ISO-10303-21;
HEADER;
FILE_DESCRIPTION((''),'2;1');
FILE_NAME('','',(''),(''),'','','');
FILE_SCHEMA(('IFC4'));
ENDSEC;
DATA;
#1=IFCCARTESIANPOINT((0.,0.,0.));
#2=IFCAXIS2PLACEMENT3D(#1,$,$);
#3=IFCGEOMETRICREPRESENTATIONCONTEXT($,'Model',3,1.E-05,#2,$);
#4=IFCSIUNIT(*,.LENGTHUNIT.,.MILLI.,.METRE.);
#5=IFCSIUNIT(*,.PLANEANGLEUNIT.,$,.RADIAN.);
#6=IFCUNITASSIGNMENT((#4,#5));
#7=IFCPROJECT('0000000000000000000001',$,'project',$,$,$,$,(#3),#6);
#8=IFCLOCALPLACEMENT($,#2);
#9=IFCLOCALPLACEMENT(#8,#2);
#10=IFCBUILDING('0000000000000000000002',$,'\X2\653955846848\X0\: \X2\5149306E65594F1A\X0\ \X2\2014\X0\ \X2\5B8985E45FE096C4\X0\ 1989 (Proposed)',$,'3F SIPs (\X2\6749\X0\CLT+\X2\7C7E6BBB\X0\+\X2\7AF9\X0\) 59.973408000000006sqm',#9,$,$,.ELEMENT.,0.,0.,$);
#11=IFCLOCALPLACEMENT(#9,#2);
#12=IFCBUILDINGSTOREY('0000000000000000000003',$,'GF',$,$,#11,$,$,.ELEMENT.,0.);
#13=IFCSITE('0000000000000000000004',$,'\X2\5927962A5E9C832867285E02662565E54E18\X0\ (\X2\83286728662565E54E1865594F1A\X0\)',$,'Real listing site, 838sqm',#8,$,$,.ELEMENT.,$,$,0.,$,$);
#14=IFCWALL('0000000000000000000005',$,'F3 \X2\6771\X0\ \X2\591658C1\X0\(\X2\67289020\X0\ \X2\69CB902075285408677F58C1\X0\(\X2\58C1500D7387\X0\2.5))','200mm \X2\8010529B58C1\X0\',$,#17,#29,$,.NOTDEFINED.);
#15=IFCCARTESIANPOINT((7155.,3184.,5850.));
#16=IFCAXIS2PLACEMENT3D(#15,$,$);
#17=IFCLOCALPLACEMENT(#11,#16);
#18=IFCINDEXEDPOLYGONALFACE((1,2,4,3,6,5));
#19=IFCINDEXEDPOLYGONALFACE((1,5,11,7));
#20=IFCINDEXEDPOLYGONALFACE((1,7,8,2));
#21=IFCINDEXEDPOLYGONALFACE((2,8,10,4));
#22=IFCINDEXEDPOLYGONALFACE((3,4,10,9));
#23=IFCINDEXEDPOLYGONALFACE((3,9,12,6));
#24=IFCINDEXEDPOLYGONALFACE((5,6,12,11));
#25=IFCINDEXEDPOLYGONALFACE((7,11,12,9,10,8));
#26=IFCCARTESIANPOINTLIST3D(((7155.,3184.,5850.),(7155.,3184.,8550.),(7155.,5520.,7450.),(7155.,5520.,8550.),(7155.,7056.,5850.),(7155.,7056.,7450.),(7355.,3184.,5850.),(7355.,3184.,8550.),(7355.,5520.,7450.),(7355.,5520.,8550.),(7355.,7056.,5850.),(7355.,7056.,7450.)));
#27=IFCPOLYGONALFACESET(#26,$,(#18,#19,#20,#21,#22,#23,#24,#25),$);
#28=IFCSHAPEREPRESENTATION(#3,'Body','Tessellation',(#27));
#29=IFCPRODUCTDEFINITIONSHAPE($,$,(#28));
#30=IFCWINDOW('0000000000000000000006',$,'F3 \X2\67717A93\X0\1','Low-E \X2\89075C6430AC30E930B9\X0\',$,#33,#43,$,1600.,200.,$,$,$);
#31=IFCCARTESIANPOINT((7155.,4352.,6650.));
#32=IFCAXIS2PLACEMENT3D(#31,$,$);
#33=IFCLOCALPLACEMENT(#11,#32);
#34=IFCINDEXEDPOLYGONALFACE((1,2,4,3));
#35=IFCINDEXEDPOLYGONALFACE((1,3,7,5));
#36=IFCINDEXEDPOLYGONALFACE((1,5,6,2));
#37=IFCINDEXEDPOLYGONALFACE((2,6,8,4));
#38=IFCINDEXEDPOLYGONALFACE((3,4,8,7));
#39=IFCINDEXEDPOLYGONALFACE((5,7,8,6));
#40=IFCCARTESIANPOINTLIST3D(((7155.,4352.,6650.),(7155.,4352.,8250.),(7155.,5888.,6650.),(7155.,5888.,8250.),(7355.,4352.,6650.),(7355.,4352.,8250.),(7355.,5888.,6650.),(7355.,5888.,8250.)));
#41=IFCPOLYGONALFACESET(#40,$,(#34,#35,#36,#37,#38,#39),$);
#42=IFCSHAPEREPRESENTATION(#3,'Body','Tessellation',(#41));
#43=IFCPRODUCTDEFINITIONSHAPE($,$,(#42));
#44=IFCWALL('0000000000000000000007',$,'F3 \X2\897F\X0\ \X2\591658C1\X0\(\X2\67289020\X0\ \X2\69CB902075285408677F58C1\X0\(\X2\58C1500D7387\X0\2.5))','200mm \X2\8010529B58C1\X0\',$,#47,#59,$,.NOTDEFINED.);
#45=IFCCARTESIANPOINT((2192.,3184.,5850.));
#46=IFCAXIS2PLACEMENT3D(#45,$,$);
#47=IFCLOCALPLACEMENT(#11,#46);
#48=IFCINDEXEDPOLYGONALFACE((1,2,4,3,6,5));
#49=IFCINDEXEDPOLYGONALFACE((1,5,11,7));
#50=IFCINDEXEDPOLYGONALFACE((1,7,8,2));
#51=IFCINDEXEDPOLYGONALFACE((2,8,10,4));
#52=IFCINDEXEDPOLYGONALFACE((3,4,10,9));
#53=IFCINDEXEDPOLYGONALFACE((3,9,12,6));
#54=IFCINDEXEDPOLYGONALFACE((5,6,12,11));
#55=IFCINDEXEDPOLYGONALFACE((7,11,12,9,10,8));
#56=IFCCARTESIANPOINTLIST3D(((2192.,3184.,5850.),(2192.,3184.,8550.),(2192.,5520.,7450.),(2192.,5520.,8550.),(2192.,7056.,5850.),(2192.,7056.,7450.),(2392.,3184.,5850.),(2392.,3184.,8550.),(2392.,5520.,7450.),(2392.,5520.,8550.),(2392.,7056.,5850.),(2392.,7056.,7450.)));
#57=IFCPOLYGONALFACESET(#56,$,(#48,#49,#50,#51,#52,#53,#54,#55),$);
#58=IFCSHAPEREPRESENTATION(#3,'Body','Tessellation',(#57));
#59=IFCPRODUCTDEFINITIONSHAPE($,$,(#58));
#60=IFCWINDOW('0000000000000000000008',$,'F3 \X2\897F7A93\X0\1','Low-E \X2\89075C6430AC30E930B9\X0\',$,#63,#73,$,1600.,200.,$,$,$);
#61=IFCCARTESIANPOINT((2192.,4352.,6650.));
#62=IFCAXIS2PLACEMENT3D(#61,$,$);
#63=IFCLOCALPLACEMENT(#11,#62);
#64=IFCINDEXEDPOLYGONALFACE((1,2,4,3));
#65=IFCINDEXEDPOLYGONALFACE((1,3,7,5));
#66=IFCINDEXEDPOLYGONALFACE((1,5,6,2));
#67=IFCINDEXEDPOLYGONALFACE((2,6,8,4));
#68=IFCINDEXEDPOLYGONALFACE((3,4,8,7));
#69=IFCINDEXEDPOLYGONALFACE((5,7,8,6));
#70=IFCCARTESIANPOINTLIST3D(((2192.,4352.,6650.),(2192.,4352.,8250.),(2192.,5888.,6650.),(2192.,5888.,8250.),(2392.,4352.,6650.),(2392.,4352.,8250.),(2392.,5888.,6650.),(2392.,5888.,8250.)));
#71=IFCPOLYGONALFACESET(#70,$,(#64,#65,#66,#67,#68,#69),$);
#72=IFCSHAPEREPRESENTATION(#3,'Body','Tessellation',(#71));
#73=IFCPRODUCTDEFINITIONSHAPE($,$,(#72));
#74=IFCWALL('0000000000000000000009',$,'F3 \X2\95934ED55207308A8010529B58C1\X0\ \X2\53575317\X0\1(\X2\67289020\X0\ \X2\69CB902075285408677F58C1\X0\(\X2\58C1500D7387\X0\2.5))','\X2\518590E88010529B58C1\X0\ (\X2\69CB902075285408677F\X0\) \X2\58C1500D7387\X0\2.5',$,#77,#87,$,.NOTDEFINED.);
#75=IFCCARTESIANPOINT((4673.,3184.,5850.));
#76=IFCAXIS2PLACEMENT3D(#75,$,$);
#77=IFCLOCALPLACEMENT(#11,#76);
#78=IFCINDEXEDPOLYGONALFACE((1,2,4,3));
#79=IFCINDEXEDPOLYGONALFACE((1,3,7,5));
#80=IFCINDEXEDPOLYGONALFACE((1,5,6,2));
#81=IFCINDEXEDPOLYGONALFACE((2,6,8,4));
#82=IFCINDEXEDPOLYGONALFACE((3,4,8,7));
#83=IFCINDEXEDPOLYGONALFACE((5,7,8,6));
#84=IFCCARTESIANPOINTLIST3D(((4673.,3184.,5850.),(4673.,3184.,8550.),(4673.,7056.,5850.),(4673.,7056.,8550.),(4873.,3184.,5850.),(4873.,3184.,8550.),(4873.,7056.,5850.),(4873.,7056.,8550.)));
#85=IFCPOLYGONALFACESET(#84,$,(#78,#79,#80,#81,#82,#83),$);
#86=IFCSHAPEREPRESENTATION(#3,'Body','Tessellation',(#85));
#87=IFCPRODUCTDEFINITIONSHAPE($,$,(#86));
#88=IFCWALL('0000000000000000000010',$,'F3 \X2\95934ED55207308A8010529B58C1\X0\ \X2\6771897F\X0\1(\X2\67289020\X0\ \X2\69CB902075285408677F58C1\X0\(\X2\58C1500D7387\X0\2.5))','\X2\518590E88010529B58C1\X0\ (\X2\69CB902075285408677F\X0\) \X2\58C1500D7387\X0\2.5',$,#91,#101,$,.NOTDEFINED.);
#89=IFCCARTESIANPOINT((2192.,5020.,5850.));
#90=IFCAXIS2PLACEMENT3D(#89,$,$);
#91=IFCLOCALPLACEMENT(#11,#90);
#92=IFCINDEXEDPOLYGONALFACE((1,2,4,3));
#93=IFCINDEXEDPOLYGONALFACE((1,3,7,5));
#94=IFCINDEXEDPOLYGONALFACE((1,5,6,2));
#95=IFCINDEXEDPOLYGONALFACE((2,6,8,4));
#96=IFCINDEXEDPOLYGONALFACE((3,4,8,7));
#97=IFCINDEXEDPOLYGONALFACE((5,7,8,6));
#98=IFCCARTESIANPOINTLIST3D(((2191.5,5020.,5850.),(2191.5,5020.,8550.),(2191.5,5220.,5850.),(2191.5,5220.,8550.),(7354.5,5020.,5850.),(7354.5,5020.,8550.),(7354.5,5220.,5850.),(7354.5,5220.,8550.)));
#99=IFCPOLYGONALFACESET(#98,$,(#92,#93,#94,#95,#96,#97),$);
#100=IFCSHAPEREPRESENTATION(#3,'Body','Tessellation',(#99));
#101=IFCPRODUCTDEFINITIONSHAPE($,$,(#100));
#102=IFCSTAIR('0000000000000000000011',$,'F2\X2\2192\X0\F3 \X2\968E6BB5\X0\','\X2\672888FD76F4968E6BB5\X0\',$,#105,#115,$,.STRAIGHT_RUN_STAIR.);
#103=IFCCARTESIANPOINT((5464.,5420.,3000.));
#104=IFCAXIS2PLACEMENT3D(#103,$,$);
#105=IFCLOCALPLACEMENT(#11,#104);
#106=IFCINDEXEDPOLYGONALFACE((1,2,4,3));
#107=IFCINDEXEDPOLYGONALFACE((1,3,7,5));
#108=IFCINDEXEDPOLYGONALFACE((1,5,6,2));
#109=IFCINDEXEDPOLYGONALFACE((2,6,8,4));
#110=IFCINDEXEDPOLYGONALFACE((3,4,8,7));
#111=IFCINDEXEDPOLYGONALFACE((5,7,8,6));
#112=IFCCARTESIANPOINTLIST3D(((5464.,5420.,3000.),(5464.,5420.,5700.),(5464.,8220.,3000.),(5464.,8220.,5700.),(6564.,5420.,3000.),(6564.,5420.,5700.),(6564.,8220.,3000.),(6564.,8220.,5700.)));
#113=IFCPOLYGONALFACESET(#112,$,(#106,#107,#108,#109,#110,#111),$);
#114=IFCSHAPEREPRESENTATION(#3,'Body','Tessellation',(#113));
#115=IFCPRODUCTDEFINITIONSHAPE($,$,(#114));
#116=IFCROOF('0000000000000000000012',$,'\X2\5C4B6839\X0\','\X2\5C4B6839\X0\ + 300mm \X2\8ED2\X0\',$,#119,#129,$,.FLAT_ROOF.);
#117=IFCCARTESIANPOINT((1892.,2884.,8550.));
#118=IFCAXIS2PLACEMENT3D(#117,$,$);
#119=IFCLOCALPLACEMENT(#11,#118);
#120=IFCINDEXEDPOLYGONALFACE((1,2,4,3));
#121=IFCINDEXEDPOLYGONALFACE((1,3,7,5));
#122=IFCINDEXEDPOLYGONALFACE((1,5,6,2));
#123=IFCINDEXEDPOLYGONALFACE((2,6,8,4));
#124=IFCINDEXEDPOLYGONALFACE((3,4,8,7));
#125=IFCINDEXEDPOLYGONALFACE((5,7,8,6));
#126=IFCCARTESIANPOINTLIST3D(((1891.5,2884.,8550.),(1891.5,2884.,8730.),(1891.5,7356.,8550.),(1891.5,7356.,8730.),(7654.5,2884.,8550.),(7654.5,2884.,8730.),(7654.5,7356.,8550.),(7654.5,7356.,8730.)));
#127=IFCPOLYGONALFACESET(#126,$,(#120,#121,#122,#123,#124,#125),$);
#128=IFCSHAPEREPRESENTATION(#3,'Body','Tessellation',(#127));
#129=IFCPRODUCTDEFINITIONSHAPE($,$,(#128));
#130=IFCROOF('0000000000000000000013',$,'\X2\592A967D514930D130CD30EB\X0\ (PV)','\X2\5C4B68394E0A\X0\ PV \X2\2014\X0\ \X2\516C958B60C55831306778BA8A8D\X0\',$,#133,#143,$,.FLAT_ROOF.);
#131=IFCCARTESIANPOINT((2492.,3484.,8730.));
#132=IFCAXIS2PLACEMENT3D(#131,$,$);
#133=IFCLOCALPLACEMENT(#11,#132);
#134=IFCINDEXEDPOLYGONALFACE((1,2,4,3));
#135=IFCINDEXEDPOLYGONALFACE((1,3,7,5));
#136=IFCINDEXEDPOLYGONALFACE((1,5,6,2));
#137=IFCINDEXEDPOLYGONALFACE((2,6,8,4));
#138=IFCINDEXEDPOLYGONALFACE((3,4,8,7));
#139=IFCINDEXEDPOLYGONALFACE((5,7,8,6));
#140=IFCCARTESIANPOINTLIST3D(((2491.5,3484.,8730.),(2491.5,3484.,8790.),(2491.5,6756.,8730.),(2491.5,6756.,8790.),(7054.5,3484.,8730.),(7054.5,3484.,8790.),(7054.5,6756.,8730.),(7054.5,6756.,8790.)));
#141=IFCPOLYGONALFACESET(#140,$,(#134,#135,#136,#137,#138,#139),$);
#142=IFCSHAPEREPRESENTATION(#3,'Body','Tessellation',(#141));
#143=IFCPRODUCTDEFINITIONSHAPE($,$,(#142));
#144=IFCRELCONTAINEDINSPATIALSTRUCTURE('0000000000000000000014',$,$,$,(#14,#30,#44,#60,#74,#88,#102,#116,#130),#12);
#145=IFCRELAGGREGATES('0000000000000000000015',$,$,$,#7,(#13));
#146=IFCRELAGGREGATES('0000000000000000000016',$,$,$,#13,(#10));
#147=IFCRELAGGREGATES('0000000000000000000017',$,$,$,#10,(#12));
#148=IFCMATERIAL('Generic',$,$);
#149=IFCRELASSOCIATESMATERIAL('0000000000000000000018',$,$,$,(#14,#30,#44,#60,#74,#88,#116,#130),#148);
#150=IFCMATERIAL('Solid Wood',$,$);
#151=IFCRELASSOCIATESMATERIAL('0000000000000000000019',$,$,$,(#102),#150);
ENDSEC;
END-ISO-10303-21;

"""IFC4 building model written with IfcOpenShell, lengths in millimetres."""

from ifc_helpers import new_model, si_unit, frame, frame_2d, origin, place, context, project, spatial, rectangle, extrude, material, element, fill, save


model = new_model("IFC4")

# Units and contexts
model_context = context("Model", 3, precision=1e-05, world=origin())
ifc_project = project(units=[si_unit("LENGTHUNIT", "METRE", prefix="MILLI"), si_unit("PLANEANGLEUNIT", "RADIAN")], contexts=[model_context])

# Site, building, storey
site_placement = place(None, origin())
site = spatial("IfcSite", under=ifc_project, at=site_placement, Name="大阪府茨木市春日丘 (茨木春日丘教会)", ObjectType="Real listing site, 838sqm", CompositionType="ELEMENT", RefElevation=0.0)
building_placement = place(site_placement, origin())
building = spatial("IfcBuilding", under=site, at=building_placement, Name="改善案: 光の教会 — 安藤忠雄 1989 (Proposed)", ObjectType="3F SIPs (杉CLT+籾殻+竹) 59.973408000000006sqm", CompositionType="ELEMENT", ElevationOfRefHeight=0.0, ElevationOfTerrain=0.0)
storey_placement = place(building_placement, origin())
storey = spatial("IfcBuildingStorey", under=building, at=storey_placement, Name="GF", CompositionType="ELEMENT", Elevation=0.0)

# Shared definitions
ifc_material_1 = material(Name="Generic")

# Walls, openings, windows
wall_1_placement = place(storey_placement, frame((7155.0, 3184.0, 5850.0)))
wall_1 = element("IfcWall", 1, at=wall_1_placement, inside=storey, material=ifc_material_1, Name="F3 東 外壁(木造 構造用合板壁(壁倍率2.5))", Description="200mm 耐力壁", PredefinedType="NOTDEFINED", context=model_context, shape_type="SweptSolid", body=[
    extrude(rectangle(XDim=200.0, YDim=3872.0, at=frame_2d((100.0, 1936.0))), frame((7155.0, 3184.0, 5850.0)), (0.0, 0.0, 1.0), 2700.0),
])
opening_1_placement = place(storey_placement, frame((7155.0, 4352.0, 6650.0)))
opening_1 = element("IfcOpeningElement", 2, at=opening_1_placement, cuts=wall_1, PredefinedType="NOTDEFINED", context=model_context, shape_type="SweptSolid", body=[
    extrude(rectangle(XDim=200.0, YDim=1536.0, at=frame_2d((100.0, 768.0))), frame((7155.0, 4352.0, 6650.0)), (0.0, 0.0, 1.0), 1600.0),
])
window_1_placement = place(storey_placement, frame((7155.0, 4352.0, 6650.0)))
window_1 = element("IfcWindow", 3, at=window_1_placement, inside=storey, material=ifc_material_1, Name="F3 東窓1", Description="Low-E 複層ガラス", OverallHeight=1600.0, OverallWidth=200.0, context=model_context, shape_type="SweptSolid", body=[
    extrude(rectangle(XDim=200.0, YDim=1536.0, at=frame_2d((100.0, 768.0))), frame((7155.0, 4352.0, 6650.0)), (0.0, 0.0, 1.0), 1600.0),
])
fill(opening_1, window_1)
wall_2_placement = place(storey_placement, frame((2192.0, 3184.0, 5850.0)))
wall_2 = element("IfcWall", 4, at=wall_2_placement, inside=storey, material=ifc_material_1, Name="F3 西 外壁(木造 構造用合板壁(壁倍率2.5))", Description="200mm 耐力壁", PredefinedType="NOTDEFINED", context=model_context, shape_type="SweptSolid", body=[
    extrude(rectangle(XDim=200.0, YDim=3872.0, at=frame_2d((100.0, 1936.0))), frame((2192.0, 3184.0, 5850.0)), (0.0, 0.0, 1.0), 2700.0),
])
opening_2_placement = place(storey_placement, frame((2192.0, 4352.0, 6650.0)))
opening_2 = element("IfcOpeningElement", 5, at=opening_2_placement, cuts=wall_2, PredefinedType="NOTDEFINED", context=model_context, shape_type="SweptSolid", body=[
    extrude(rectangle(XDim=200.0, YDim=1536.0, at=frame_2d((100.0, 768.0))), frame((2192.0, 4352.0, 6650.0)), (0.0, 0.0, 1.0), 1600.0),
])
window_2_placement = place(storey_placement, frame((2192.0, 4352.0, 6650.0)))
window_2 = element("IfcWindow", 6, at=window_2_placement, inside=storey, material=ifc_material_1, Name="F3 西窓1", Description="Low-E 複層ガラス", OverallHeight=1600.0, OverallWidth=200.0, context=model_context, shape_type="SweptSolid", body=[
    extrude(rectangle(XDim=200.0, YDim=1536.0, at=frame_2d((100.0, 768.0))), frame((2192.0, 4352.0, 6650.0)), (0.0, 0.0, 1.0), 1600.0),
])
fill(opening_2, window_2)

# Walls
wall_3_placement = place(storey_placement, frame((4673.0, 3184.0, 5850.0)))
element("IfcWall", 7, at=wall_3_placement, inside=storey, material=ifc_material_1, Name="F3 間仕切り耐力壁 南北1(木造 構造用合板壁(壁倍率2.5))", Description="内部耐力壁 (構造用合板) 壁倍率2.5", PredefinedType="NOTDEFINED", context=model_context, shape_type="SweptSolid", body=[
    extrude(rectangle(XDim=200.0, YDim=3872.0, at=frame_2d((100.0, 1936.0))), frame((4673.0, 3184.0, 5850.0)), (0.0, 0.0, 1.0), 2700.0),
])
wall_4_placement = place(storey_placement, frame((2192.0, 5020.0, 5850.0)))
element("IfcWall", 8, at=wall_4_placement, inside=storey, material=ifc_material_1, Name="F3 間仕切り耐力壁 東西1(木造 構造用合板壁(壁倍率2.5))", Description="内部耐力壁 (構造用合板) 壁倍率2.5", PredefinedType="NOTDEFINED", context=model_context, shape_type="SweptSolid", body=[
    extrude(rectangle(XDim=5163.0, YDim=200.0, at=frame_2d((2581.0, 100.0))), frame((2192.0, 5020.0, 5850.0)), (0.0, 0.0, 1.0), 2700.0),
])

# Stair
ifc_material_2 = material(Name="Solid Wood")
stair_placement = place(storey_placement, frame((5464.0, 5420.0, 3000.0)))
element("IfcStair", 9, at=stair_placement, inside=storey, material=ifc_material_2, Name="F2→F3 階段", Description="木製直階段", PredefinedType="STRAIGHT_RUN_STAIR", context=model_context, shape_type="SweptSolid", body=[
    extrude(rectangle(XDim=1100.0, YDim=2800.0, at=frame_2d((550.0, 1400.0))), frame((5464.0, 5420.0, 3000.0)), (0.0, 0.0, 1.0), 2700.0),
])

# Roofs
roof_1_placement = place(storey_placement, frame((1892.0, 2884.0, 8550.0)))
element("IfcRoof", 10, at=roof_1_placement, inside=storey, material=ifc_material_1, Name="屋根", Description="屋根 + 300mm 軒", PredefinedType="FLAT_ROOF", context=model_context, shape_type="SweptSolid", body=[
    extrude(rectangle(XDim=5763.0, YDim=4472.0, at=frame_2d((2881.0, 2236.0))), frame((1892.0, 2884.0, 8550.0)), (0.0, 0.0, 1.0), 180.0),
])
roof_2_placement = place(storey_placement, frame((2492.0, 3484.0, 8730.0)))
element("IfcRoof", 11, at=roof_2_placement, inside=storey, material=ifc_material_1, Name="太陽光パネル (PV)", Description="屋根上 PV — 公開情報で確認", PredefinedType="FLAT_ROOF", context=model_context, shape_type="SweptSolid", body=[
    extrude(rectangle(XDim=4563.0, YDim=3272.0, at=frame_2d((2281.0, 1636.0))), frame((2492.0, 3484.0, 8730.0)), (0.0, 0.0, 1.0), 60.0),
])

save(model, "model.ifc")
